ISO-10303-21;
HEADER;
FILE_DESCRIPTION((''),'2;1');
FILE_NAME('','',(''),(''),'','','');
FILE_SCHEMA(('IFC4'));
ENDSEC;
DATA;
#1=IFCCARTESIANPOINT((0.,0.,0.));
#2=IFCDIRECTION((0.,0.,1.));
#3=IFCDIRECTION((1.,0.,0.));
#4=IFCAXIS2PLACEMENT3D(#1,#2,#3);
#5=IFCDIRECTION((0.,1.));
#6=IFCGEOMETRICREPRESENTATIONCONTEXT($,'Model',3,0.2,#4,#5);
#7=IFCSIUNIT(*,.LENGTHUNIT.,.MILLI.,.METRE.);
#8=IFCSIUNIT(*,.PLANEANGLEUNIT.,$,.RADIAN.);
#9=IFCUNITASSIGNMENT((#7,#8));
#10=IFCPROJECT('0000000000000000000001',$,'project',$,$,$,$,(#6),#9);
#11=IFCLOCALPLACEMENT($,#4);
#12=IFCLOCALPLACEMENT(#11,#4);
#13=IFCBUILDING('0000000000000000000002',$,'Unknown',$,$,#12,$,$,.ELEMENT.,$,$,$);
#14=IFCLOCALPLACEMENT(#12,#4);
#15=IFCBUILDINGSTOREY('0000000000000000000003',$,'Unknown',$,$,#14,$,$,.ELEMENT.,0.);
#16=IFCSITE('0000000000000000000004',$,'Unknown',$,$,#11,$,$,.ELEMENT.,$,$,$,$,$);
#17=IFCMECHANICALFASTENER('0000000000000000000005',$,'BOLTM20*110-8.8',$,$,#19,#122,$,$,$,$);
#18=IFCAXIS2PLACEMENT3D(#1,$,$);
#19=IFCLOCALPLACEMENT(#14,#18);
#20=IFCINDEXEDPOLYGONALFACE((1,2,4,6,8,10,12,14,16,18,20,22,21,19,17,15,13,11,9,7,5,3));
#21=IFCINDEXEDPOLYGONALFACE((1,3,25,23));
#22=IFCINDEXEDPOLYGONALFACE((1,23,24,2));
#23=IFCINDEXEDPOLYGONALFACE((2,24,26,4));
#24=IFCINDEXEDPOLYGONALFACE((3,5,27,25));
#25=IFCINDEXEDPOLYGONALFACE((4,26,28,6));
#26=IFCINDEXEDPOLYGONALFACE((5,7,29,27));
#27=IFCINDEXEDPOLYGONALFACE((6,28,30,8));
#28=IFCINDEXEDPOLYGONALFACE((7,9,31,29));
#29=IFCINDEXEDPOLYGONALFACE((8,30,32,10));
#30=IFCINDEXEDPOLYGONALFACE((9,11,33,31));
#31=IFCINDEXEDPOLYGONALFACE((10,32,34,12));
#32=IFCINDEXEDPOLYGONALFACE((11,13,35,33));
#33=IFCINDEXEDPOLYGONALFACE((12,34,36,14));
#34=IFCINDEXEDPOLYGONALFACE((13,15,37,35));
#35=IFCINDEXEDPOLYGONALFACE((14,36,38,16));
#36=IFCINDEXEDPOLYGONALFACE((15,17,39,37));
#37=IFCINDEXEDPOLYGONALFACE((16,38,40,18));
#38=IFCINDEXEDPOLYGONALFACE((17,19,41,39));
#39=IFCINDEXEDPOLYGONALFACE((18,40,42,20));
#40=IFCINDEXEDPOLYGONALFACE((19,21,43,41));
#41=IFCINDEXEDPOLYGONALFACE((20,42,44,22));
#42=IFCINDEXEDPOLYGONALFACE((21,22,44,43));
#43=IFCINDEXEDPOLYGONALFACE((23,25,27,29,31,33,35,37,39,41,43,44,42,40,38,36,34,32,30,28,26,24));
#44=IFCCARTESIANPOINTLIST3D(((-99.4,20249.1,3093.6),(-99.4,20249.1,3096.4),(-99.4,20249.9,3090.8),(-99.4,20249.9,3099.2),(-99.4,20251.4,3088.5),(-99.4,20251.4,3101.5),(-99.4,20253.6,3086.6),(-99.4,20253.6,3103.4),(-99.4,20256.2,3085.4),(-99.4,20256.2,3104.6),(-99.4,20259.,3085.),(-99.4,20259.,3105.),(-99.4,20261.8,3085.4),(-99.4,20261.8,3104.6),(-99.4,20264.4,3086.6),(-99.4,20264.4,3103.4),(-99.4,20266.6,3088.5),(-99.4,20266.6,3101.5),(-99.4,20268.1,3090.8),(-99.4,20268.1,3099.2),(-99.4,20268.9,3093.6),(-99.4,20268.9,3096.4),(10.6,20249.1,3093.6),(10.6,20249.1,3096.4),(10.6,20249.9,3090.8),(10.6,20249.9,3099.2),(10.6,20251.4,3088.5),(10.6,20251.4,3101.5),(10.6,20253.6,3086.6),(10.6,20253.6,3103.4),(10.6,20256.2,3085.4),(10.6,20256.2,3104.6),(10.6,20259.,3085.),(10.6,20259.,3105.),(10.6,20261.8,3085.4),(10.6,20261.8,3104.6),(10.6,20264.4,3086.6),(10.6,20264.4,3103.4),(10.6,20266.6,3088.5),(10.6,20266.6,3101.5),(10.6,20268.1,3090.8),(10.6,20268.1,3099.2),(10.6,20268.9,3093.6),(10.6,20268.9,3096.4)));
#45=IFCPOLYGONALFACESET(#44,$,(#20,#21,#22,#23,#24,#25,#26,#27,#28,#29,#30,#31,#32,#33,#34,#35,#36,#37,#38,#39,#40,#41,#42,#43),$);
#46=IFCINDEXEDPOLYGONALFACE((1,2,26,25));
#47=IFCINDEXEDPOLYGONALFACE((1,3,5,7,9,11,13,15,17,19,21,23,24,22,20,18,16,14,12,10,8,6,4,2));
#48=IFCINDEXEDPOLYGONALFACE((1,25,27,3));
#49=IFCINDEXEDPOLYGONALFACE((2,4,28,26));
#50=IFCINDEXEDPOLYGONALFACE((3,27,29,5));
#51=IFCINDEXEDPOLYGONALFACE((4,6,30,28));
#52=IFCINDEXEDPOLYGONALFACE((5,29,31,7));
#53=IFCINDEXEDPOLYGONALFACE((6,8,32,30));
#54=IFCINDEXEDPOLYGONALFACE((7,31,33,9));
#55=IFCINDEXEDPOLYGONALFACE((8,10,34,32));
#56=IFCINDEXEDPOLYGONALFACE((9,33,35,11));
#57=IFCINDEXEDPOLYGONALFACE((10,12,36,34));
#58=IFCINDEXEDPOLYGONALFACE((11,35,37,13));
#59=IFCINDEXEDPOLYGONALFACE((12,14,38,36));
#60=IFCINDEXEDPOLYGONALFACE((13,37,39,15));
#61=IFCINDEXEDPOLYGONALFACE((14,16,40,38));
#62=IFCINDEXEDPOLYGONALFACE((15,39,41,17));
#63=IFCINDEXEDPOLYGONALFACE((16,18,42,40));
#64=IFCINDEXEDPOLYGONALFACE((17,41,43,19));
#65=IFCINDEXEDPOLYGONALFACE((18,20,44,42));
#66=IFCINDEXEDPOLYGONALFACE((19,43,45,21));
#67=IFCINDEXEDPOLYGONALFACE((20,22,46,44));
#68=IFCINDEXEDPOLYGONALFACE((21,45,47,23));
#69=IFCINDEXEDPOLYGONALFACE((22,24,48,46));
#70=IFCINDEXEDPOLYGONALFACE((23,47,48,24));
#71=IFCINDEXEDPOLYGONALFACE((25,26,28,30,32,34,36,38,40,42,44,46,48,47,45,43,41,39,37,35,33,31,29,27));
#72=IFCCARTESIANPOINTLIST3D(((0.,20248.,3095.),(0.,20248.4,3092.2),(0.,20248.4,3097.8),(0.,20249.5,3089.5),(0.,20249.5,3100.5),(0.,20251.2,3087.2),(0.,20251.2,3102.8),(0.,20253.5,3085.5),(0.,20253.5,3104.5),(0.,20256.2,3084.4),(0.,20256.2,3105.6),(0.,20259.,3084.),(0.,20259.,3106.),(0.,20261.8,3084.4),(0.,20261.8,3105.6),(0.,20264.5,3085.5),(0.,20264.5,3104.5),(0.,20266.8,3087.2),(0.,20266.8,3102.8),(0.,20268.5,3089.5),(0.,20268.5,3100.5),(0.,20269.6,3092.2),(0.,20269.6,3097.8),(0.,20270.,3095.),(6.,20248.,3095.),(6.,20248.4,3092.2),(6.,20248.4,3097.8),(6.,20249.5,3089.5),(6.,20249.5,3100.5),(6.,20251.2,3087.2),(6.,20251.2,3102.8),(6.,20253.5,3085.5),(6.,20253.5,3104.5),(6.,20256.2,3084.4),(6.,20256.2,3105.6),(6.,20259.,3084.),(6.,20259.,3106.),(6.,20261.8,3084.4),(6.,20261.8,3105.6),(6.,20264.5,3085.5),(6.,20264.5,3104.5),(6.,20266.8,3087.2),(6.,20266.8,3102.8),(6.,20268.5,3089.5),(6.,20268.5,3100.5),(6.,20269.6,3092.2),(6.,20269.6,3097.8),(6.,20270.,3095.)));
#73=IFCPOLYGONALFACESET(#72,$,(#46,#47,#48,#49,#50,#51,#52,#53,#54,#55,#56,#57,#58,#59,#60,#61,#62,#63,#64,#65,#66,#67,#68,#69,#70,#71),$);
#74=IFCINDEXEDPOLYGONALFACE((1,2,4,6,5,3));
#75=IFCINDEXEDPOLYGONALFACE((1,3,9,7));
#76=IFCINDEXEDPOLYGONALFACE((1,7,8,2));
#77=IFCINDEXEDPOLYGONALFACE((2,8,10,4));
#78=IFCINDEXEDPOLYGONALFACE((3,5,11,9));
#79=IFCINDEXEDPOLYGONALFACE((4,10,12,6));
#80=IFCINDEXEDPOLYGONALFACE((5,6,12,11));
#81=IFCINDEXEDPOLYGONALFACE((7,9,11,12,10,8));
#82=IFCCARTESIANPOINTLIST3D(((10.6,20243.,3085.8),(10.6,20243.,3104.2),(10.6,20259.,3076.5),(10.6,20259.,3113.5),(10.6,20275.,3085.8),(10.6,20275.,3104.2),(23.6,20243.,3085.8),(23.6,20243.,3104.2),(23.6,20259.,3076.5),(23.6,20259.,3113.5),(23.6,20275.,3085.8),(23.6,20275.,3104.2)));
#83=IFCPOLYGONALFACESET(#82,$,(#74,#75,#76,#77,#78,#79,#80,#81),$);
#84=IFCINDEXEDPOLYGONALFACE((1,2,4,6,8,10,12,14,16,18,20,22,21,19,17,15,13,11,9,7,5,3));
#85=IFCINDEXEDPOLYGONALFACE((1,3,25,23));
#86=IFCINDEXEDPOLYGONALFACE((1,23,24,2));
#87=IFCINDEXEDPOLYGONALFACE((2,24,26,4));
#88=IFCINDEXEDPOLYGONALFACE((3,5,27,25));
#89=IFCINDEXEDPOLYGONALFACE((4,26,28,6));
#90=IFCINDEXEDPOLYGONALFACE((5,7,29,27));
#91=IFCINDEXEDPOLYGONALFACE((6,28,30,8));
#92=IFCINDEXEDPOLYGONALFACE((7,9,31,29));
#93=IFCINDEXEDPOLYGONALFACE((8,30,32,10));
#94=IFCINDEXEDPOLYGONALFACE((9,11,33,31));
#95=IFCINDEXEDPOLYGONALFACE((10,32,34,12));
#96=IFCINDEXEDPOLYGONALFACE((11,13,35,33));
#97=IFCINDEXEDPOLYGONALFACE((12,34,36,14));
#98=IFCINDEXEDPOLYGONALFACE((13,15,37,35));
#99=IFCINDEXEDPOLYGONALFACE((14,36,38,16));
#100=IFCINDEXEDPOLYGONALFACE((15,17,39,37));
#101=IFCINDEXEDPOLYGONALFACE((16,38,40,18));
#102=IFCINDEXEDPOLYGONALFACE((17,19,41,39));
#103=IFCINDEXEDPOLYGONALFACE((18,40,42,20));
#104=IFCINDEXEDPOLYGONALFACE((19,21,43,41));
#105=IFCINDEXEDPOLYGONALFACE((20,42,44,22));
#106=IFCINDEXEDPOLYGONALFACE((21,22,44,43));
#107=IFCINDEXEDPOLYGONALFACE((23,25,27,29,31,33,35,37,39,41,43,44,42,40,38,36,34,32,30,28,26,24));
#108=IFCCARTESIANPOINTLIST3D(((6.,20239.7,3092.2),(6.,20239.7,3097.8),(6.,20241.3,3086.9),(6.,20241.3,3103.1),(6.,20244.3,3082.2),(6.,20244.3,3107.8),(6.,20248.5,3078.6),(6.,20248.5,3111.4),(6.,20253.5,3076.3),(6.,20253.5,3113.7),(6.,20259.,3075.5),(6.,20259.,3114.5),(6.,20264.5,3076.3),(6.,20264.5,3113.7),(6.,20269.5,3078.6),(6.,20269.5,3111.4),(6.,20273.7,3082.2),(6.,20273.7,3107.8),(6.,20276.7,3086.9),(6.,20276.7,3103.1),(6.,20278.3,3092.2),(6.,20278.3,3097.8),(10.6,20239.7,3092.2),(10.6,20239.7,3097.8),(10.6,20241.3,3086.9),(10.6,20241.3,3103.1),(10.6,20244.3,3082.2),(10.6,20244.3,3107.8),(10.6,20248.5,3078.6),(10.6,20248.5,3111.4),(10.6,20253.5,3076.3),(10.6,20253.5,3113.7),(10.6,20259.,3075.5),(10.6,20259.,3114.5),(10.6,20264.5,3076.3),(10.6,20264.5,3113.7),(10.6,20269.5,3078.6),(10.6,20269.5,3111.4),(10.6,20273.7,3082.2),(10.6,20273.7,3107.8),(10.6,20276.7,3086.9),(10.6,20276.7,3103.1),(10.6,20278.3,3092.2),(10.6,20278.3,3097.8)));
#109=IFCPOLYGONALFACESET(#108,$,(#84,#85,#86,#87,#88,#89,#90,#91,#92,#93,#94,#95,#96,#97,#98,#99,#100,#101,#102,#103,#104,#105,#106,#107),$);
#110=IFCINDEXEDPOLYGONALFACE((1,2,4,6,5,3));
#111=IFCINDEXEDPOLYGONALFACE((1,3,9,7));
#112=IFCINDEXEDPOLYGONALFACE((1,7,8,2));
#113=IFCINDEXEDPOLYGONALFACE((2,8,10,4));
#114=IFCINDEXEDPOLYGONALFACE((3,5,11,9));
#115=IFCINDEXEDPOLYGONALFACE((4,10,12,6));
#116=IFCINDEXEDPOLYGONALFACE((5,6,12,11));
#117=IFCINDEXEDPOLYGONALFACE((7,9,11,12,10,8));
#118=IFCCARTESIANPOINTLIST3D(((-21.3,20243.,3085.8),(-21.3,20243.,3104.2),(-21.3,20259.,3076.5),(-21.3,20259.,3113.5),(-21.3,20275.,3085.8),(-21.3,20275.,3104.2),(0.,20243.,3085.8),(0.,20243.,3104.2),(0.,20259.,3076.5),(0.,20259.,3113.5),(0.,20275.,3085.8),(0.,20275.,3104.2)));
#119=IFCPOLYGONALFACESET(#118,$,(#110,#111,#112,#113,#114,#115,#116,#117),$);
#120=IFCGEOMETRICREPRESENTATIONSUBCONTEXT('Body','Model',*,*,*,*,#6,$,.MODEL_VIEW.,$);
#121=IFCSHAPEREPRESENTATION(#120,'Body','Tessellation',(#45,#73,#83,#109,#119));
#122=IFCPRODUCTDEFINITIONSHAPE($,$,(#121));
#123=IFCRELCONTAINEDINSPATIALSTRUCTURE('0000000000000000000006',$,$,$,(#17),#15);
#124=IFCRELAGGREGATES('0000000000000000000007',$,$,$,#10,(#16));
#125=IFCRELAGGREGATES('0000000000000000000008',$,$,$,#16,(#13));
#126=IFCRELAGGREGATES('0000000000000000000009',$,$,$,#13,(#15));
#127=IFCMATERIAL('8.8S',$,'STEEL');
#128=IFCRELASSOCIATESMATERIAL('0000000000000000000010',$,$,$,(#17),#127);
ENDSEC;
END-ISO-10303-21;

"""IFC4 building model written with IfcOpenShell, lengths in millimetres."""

from ifc_helpers import new_model, si_unit, direction, frame, origin_with_axes, place, context, subcontext, project, spatial, line, arc, indexed_curve, outline, extrude, source, transform, mapped, material, element, save


model = new_model("IFC4")

# Units and contexts
model_context = context("Model", 3, precision=0.2, world=origin_with_axes(), true_north=direction((0.0, 1.0)))
body_context = subcontext(model_context, "Body", "Model", "MODEL_VIEW")
ifc_project = project(units=[si_unit("LENGTHUNIT", "METRE", prefix="MILLI"), si_unit("PLANEANGLEUNIT", "RADIAN")], contexts=[model_context])

# Site, building, storey
site_placement = place(None, origin_with_axes())
site = spatial("IfcSite", under=ifc_project, at=site_placement, Name="Unknown", CompositionType="ELEMENT")
building_placement = place(site_placement, origin_with_axes())
building = spatial("IfcBuilding", under=site, at=building_placement, Name="Unknown", CompositionType="ELEMENT")
storey_placement = place(building_placement, origin_with_axes())
storey = spatial("IfcBuildingStorey", under=building, at=storey_placement, Name="Unknown", CompositionType="ELEMENT", Elevation=0.0)

# Mechanical fastener
ifc_material_1 = material(Name="8.8S", Category="STEEL")
shared_shape_1 = source(origin_with_axes(), body_context, "Body", "SweptSolid", [
    extrude(outline(indexed_curve([(10.0, 0.0), (0.0, 10.0), (-10.0, 0.0), (0.0, -10.0)], segments=[arc(1, 2, 3), arc(3, 4, 1)])), frame((0.0, 0.0, 4.6), z_axis=(0.0, 0.0, -1.0), x_axis=(0.0, 1.0, 0.0)), (0.0, 0.0, 1.0), 110.0),
    extrude(outline(indexed_curve([(0.0, 11.0), (7.8, 7.8), (11.0, 0.0), (7.8, -7.8), (0.0, -11.0), (-1.0, -11.0), (-11.0, 0.0), (-7.8, 7.8)], segments=[arc(1, 2, 3), arc(3, 4, 5), arc(5, 6, 7), arc(7, 8, 1)])), frame((0.0, 0.0, 0.0), z_axis=(0.0, 0.0, -1.0), x_axis=(0.0, 1.0, 0.0)), (0.0, 0.0, 1.0), 6.0),
    extrude(outline(indexed_curve([(18.5, 0.0), (9.2, 16.0), (-9.2, 16.0), (-18.5, 0.0), (-9.2, -16.0), (9.2, -16.0)], segments=[line(1, 2, 3, 4, 5, 6, 1)])), frame((0.0, 0.0, 17.6), z_axis=(0.0, 0.0, -1.0), x_axis=(0.0, 1.0, 0.0)), (0.0, 0.0, 1.0), 13.0),
    extrude(outline(indexed_curve([(19.5, 0.0), (0.0, 19.5), (-19.5, 0.0), (0.0, -19.5)], segments=[arc(1, 2, 3), arc(3, 4, 1)])), frame((0.0, 0.0, 4.6), z_axis=(0.0, 0.0, -1.0), x_axis=(0.0, 1.0, 0.0)), (0.0, 0.0, 1.0), 4.6),
    extrude(outline(indexed_curve([(18.5, 0.0), (9.2, 16.0), (-9.2, 16.0), (-18.5, 0.0), (-9.2, -16.0), (9.2, -16.0)], segments=[line(1, 2, 3, 4, 5, 6, 1)])), frame((0.0, 0.0, -6.0), z_axis=(0.0, 0.0, -1.0), x_axis=(0.0, 1.0, 0.0)), (0.0, 0.0, 1.0), 21.3),
])
mechanical_fastener_1_placement = place(storey_placement, frame((6.0, 20259.0, 3095.0), z_axis=(1.0, 0.0, 0.0), x_axis=(0.0, 1.0, 0.0)))
element("IfcMechanicalFastener", 1, at=mechanical_fastener_1_placement, inside=storey, material=ifc_material_1, Name="BOLTM20*110-8.8", context=body_context, shape_type="MappedRepresentation", body=[
    mapped(shared_shape_1, transform((0.0, 0.0, 0.0))),
])

save(model, "model.ifc")
